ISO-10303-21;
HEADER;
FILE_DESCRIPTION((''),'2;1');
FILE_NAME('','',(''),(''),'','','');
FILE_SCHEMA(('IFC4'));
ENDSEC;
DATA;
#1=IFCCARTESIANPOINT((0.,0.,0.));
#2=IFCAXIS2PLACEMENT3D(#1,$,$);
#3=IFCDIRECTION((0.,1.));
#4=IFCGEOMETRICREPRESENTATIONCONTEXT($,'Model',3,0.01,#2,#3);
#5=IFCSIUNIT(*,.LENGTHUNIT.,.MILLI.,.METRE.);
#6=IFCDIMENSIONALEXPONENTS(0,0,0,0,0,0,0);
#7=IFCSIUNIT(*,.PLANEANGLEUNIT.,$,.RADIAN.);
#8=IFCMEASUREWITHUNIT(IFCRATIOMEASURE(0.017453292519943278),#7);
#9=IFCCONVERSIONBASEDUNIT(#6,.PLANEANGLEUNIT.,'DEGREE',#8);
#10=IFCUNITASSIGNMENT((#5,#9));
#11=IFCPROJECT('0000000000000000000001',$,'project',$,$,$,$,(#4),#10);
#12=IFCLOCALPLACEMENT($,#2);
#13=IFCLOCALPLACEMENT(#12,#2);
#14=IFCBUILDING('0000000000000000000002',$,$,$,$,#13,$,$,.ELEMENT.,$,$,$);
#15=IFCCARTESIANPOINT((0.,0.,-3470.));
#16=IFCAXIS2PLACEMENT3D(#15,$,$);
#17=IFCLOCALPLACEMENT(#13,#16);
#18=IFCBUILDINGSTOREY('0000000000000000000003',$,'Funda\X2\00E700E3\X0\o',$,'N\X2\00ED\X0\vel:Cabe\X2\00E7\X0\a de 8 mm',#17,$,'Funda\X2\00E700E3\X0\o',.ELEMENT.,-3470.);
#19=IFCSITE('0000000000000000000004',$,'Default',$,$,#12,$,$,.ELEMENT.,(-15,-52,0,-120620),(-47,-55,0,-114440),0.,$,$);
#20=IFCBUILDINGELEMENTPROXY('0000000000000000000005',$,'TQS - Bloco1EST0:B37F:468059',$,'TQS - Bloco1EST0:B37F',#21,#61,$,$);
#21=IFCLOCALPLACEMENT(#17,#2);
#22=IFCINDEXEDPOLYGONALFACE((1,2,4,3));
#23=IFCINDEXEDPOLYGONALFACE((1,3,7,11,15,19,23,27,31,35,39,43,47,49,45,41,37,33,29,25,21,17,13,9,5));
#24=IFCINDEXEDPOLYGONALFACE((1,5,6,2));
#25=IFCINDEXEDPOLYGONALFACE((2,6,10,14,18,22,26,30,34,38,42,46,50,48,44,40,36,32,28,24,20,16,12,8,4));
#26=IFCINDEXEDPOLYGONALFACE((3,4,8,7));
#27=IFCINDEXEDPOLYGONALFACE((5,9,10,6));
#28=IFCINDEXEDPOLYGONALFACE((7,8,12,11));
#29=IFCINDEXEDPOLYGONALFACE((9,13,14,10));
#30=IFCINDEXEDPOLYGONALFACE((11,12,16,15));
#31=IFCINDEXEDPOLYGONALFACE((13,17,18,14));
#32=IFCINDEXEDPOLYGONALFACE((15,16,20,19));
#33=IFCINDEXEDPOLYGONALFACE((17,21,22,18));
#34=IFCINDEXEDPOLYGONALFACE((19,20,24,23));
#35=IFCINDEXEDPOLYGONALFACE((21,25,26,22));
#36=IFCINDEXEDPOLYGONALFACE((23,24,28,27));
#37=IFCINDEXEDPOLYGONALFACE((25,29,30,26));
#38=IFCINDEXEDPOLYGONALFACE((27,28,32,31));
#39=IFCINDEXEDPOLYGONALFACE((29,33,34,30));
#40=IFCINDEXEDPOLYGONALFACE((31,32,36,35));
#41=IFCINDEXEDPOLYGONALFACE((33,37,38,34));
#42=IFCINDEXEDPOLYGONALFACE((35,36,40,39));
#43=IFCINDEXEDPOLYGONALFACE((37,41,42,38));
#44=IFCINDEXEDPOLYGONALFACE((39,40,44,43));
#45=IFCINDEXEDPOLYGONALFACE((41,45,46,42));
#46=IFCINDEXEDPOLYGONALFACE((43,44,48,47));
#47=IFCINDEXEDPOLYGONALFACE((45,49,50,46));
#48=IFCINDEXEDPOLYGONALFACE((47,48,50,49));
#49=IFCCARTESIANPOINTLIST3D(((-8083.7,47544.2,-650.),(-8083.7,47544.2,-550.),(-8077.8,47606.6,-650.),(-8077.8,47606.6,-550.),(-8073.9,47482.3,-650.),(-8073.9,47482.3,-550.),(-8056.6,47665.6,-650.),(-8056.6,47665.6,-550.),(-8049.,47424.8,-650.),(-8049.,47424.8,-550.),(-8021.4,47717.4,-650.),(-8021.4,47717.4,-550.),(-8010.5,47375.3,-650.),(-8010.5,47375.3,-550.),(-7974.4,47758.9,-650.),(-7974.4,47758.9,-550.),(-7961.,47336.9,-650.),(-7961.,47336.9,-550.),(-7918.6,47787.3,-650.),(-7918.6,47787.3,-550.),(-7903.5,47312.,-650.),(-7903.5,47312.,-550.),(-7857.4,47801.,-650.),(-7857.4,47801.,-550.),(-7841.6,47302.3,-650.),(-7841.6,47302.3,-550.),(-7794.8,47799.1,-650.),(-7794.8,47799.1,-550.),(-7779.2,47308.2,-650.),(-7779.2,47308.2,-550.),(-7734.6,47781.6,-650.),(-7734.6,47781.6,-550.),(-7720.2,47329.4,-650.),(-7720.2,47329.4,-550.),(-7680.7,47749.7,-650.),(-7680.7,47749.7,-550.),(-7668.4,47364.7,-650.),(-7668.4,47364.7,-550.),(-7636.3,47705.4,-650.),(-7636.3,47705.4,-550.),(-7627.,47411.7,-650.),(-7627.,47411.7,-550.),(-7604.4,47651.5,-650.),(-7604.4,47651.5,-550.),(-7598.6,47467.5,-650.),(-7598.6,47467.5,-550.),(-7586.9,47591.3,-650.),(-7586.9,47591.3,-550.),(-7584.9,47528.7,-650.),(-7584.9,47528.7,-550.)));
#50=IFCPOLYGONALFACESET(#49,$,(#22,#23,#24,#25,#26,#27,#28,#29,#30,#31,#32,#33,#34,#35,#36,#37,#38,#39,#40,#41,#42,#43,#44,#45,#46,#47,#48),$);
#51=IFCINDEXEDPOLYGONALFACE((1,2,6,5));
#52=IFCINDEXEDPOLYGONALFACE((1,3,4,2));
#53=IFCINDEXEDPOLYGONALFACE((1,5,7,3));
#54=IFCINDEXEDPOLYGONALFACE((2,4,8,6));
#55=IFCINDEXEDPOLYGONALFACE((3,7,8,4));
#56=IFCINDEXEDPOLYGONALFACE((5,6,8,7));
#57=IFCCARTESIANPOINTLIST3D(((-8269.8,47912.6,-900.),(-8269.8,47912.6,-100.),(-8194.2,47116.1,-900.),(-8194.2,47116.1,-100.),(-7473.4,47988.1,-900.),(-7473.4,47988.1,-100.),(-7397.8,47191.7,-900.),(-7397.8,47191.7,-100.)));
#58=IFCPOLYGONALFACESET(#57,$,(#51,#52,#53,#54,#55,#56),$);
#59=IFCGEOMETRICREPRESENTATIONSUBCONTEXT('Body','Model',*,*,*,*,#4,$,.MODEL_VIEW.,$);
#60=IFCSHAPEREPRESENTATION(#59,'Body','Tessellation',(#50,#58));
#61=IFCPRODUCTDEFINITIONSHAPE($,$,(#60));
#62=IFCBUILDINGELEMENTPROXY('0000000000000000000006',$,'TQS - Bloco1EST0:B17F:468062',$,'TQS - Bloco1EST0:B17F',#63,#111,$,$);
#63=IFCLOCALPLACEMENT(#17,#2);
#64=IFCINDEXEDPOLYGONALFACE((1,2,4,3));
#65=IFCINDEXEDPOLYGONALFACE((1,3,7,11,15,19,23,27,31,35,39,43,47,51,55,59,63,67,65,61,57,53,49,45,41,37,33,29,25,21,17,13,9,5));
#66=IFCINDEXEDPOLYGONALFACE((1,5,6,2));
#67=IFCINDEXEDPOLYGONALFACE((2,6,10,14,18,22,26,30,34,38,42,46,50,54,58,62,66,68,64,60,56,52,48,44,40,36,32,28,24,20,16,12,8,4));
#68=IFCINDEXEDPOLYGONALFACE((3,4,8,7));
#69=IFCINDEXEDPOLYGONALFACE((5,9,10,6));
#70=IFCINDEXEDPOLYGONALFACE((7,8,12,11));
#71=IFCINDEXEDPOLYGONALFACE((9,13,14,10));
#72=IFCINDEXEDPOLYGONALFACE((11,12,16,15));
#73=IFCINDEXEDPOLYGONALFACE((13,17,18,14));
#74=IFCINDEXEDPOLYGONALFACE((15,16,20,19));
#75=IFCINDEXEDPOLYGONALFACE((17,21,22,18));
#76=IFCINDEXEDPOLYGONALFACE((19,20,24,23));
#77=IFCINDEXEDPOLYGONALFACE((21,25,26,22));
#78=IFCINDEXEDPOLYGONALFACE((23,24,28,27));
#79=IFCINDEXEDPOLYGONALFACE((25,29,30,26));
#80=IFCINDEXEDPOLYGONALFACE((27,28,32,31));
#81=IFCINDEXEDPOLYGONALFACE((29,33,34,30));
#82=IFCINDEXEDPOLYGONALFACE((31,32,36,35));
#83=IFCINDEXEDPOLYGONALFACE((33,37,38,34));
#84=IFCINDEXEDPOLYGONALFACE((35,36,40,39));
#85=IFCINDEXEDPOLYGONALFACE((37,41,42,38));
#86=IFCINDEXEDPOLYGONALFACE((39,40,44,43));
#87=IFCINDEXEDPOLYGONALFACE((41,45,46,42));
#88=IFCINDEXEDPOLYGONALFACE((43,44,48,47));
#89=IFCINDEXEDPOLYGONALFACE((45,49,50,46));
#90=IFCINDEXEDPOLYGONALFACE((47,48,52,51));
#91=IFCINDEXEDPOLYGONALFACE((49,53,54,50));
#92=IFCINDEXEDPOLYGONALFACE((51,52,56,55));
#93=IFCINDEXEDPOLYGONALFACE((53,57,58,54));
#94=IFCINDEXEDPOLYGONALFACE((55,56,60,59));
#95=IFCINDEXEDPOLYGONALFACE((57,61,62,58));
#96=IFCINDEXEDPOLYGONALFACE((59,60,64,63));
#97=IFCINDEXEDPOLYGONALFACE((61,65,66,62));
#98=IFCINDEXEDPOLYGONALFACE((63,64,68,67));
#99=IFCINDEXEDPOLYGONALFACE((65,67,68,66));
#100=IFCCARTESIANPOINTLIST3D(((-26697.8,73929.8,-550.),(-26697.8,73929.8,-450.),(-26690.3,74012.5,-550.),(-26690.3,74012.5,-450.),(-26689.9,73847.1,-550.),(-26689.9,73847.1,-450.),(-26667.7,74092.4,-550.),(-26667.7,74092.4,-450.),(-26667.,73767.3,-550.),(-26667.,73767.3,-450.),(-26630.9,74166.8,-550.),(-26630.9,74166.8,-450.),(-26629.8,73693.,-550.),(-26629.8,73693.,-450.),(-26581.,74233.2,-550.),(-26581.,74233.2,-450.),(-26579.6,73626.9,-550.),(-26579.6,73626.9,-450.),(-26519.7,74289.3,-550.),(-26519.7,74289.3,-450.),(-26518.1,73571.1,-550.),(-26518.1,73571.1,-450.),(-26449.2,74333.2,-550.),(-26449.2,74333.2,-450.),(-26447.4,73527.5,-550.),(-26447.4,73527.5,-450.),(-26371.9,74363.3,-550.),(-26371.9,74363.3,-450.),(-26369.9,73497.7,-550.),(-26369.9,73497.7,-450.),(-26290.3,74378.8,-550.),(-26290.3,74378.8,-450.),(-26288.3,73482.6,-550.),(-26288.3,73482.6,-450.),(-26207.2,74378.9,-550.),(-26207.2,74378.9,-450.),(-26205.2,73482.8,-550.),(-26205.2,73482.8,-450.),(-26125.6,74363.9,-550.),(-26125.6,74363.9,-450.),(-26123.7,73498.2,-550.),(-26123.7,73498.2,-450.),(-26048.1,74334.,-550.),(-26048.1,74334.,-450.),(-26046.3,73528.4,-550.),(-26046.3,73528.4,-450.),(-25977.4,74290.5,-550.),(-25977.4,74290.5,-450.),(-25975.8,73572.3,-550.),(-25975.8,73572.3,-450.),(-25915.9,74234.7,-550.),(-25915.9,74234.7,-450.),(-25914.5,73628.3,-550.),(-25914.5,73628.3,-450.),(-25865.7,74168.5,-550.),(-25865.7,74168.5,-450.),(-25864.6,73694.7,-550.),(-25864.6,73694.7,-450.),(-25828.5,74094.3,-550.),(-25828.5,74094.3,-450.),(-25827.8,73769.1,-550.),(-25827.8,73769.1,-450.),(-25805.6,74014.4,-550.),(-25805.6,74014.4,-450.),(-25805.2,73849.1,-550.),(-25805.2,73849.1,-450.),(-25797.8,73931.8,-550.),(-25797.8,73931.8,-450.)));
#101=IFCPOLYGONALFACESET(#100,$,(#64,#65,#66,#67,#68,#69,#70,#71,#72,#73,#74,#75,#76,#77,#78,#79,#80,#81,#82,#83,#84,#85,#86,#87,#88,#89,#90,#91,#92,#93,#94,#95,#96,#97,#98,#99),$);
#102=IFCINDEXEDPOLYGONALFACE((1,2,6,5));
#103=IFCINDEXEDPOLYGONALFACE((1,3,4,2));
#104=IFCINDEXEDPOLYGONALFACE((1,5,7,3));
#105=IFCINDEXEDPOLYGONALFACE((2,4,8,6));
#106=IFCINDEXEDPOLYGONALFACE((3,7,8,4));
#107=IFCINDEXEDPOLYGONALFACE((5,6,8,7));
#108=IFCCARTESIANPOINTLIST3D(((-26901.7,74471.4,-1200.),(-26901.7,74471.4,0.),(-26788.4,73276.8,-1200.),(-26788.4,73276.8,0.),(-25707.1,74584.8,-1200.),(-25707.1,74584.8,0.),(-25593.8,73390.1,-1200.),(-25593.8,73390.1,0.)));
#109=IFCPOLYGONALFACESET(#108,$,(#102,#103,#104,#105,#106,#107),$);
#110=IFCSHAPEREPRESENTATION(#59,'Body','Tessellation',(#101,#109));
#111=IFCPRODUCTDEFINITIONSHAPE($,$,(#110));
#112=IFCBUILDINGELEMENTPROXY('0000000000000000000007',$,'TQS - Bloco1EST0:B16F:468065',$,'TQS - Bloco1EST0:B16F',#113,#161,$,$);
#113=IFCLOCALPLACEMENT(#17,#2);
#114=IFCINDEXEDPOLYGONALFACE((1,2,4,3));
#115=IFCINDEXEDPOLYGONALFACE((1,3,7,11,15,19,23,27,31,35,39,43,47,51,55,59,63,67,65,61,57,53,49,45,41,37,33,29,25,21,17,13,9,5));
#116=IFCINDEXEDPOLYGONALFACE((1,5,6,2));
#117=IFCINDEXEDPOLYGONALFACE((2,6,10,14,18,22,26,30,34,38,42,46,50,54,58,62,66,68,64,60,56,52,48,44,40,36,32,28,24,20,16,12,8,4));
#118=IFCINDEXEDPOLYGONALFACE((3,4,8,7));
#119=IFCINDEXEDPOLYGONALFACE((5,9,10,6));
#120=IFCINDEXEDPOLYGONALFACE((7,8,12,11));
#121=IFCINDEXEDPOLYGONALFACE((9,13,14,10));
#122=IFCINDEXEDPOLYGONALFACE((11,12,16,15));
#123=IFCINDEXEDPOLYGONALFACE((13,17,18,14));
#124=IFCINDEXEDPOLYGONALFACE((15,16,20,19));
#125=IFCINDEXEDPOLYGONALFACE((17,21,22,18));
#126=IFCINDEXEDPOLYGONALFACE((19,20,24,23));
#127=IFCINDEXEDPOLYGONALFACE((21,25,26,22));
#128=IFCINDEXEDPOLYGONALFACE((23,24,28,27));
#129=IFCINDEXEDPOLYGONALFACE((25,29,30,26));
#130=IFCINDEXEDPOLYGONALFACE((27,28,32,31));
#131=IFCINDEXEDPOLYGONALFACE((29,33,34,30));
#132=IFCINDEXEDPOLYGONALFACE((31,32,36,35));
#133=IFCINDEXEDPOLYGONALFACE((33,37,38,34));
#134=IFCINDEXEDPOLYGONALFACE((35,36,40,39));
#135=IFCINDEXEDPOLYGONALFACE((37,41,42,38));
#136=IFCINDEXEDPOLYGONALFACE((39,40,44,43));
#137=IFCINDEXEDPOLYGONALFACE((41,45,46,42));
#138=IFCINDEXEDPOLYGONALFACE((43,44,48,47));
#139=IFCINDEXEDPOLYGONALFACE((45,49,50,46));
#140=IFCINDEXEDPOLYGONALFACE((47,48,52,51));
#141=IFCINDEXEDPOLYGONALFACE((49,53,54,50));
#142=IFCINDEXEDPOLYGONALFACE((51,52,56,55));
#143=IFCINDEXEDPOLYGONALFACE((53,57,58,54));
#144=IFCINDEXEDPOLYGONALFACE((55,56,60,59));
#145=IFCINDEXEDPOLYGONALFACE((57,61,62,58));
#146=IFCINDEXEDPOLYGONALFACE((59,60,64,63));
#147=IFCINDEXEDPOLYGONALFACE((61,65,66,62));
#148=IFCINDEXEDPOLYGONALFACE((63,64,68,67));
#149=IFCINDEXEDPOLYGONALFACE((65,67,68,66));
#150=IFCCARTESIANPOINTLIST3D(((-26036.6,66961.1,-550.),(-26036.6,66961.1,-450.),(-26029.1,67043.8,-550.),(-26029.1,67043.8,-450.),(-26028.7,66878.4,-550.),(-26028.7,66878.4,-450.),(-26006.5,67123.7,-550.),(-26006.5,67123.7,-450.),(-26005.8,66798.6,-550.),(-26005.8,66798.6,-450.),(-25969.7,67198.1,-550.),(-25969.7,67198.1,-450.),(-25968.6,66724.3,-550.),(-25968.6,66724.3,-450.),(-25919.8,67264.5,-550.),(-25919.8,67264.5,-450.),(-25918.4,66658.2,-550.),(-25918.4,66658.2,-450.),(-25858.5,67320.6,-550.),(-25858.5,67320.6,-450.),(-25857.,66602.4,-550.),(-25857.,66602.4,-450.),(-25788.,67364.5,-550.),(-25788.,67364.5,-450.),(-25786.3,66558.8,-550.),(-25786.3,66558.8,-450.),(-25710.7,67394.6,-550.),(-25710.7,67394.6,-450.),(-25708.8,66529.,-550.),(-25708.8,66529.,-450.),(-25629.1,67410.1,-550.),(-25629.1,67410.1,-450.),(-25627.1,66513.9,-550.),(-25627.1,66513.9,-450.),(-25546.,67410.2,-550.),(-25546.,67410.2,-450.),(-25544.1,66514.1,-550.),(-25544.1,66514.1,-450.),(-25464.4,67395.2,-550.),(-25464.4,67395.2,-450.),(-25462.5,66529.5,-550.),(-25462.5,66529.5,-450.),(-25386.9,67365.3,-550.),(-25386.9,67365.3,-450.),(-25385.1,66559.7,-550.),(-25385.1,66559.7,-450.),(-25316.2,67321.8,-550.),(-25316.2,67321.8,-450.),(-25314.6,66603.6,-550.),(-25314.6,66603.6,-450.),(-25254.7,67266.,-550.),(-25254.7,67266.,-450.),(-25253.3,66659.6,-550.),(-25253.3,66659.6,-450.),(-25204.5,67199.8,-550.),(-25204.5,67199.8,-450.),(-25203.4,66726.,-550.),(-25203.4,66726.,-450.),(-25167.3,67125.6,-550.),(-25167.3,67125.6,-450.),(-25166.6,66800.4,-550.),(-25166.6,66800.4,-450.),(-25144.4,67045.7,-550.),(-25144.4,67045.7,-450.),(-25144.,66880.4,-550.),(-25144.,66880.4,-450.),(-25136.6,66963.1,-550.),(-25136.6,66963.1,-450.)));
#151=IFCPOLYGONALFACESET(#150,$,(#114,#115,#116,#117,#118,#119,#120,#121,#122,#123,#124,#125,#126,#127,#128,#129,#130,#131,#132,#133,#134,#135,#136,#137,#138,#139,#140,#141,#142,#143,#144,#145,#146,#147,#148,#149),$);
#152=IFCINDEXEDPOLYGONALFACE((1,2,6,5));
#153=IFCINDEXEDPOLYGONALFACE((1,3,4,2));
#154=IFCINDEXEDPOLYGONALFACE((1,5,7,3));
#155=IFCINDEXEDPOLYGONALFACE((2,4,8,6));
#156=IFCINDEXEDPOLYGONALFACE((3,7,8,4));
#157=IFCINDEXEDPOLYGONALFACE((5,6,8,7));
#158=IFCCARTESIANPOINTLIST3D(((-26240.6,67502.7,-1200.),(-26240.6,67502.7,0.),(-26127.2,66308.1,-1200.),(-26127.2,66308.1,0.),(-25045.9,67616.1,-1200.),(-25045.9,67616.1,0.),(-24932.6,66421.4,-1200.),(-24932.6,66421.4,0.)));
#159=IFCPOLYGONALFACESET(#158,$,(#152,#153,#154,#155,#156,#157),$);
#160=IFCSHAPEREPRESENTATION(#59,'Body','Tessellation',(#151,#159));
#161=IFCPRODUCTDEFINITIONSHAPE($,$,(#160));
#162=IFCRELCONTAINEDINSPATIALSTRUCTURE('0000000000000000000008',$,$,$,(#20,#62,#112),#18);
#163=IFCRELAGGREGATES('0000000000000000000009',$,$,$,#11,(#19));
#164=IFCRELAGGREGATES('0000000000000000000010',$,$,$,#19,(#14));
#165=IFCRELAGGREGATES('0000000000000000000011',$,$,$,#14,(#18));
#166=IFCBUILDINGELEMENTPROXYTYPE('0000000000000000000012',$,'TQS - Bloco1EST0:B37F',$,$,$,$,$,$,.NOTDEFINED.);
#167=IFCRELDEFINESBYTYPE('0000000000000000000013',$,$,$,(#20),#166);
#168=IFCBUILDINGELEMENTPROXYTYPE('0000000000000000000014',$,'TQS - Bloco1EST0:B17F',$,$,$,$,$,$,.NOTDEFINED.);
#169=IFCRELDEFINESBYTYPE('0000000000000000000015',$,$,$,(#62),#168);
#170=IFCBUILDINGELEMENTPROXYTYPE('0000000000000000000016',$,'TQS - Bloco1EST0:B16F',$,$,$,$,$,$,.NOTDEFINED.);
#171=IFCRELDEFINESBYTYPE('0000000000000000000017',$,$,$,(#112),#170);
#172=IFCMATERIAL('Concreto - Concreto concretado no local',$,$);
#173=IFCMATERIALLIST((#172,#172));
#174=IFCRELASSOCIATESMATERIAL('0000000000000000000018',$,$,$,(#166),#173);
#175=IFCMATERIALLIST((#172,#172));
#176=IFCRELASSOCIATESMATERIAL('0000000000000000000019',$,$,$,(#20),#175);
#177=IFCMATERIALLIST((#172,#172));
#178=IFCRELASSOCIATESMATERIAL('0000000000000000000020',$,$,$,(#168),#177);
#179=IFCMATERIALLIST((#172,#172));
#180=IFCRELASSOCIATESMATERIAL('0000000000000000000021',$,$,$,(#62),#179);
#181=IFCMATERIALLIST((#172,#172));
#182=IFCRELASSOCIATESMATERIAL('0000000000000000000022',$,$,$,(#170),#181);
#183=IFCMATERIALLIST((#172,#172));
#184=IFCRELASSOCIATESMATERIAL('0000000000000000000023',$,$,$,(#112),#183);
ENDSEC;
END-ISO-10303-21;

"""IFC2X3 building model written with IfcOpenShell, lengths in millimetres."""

from ifc_helpers import new_model, entity, si_unit, converted_unit, direction, frame, frame_2d, origin, origin_2d_with_axis, place, context, subcontext, project, spatial, rectangle, circle, extrude, source, transform, mapped, material, material_list, type_object, type_shapes, element, save


model = new_model("IFC2X3")

# Units and contexts
model_context = context("Model", 3, precision=0.01, world=origin(), true_north=direction((0.0, 1.0)))
body_context = subcontext(model_context, "Body", "Model", "MODEL_VIEW")
ifc_project = project(units=[si_unit("LENGTHUNIT", "METRE", prefix="MILLI"), converted_unit("PLANEANGLEUNIT", "DEGREE", entity("IfcRatioMeasure", 0.017453292519943278), si_unit("PLANEANGLEUNIT", "RADIAN"), dimensions=[0, 0, 0, 0, 0, 0, 0])], contexts=[model_context])

# Site, building, storey
site_placement = place(None, origin())
site = spatial("IfcSite", under=ifc_project, at=site_placement, Name="Default", CompositionType="ELEMENT", RefLatitude=(-15, -52, 0, -120620), RefLongitude=(-47, -55, 0, -114440), RefElevation=0.0)
building_placement = place(site_placement, origin())
building = spatial("IfcBuilding", under=site, at=building_placement, CompositionType="ELEMENT")
storey_placement = place(building_placement, frame((0.0, 0.0, -3470.0)))
storey = spatial("IfcBuildingStorey", under=building, at=storey_placement, Name="Fundação", ObjectType="Nível:Cabeça de 8 mm", LongName="Fundação", CompositionType="ELEMENT", Elevation=-3470.0)

# Building element proxies
ifc_material_1 = material(Name="Concreto - Concreto concretado no local")
ifc_material_list_1 = material_list([ifc_material_1, ifc_material_1])
ifc_material_list_2 = material_list([ifc_material_1, ifc_material_1])
building_element_proxy_type_1 = type_object("IfcBuildingElementProxyType", Name="TQS - Bloco1EST0:B37F", PredefinedType="NOTDEFINED", material=ifc_material_list_2)
shared_shape_1 = source(origin(), body_context, "Body", "SweptSolid", [
    extrude(circle(Radius=250.0, at=frame_2d((0.0, 0.0), x_axis=(1.0, 0.0))), frame((0.0, 0.0, -550.0)), (0.0, 0.0, 1.0), 100.0),
    extrude(rectangle(XDim=800.0, YDim=800.0, at=origin_2d_with_axis()), frame((0.0, 0.0, -800.0), z_axis=(0.0, 0.0, 1.0), x_axis=(-1.0, 0.0, 0.0)), (0.0, 0.0, 1.0), 800.0),
])
type_shapes(building_element_proxy_type_1, [shared_shape_1])
proxy_1_placement = place(storey_placement, frame((-7833.8, 47552.1, -100.0), z_axis=(0.0, 0.0, 1.0), x_axis=(-0.094456, 0.995529, 0.0)))
element("IfcBuildingElementProxy", 1, at=proxy_1_placement, inside=storey, type_object=building_element_proxy_type_1, material=ifc_material_list_1, Name="TQS - Bloco1EST0:B37F:468059", ObjectType="TQS - Bloco1EST0:B37F", context=body_context, shape_type="MappedRepresentation", body=[
    mapped(shared_shape_1, transform((0.0, 0.0, 0.0), scale=1.0)),
])
ifc_material_list_3 = material_list([ifc_material_1, ifc_material_1])
ifc_material_list_4 = material_list([ifc_material_1, ifc_material_1])
building_element_proxy_type_2 = type_object("IfcBuildingElementProxyType", Name="TQS - Bloco1EST0:B17F", PredefinedType="NOTDEFINED", material=ifc_material_list_4)
shared_shape_2 = source(origin(), body_context, "Body", "SweptSolid", [
    extrude(circle(Radius=450.0, at=frame_2d((0.0, 0.0), x_axis=(1.0, 0.0))), frame((0.0, 0.0, -550.0)), (0.0, 0.0, 1.0), 100.0),
    extrude(rectangle(XDim=1200.0, YDim=1200.0, at=origin_2d_with_axis()), frame((0.0, 0.0, -1200.0), z_axis=(0.0, 0.0, 1.0), x_axis=(-1.0, 0.0, 0.0)), (0.0, 0.0, 1.0), 1200.0),
])
type_shapes(building_element_proxy_type_2, [shared_shape_2])
proxy_2_placement = place(storey_placement, frame((-26247.8, 73930.8, 0.0), z_axis=(0.0, 0.0, 1.0), x_axis=(-0.094456, 0.995529, 0.0)))
element("IfcBuildingElementProxy", 2, at=proxy_2_placement, inside=storey, type_object=building_element_proxy_type_2, material=ifc_material_list_3, Name="TQS - Bloco1EST0:B17F:468062", ObjectType="TQS - Bloco1EST0:B17F", context=body_context, shape_type="MappedRepresentation", body=[
    mapped(shared_shape_2, transform((0.0, 0.0, 0.0), scale=1.0)),
])
ifc_material_list_5 = material_list([ifc_material_1, ifc_material_1])
ifc_material_list_6 = material_list([ifc_material_1, ifc_material_1])
building_element_proxy_type_3 = type_object("IfcBuildingElementProxyType", Name="TQS - Bloco1EST0:B16F", PredefinedType="NOTDEFINED", material=ifc_material_list_6)
shared_shape_3 = source(origin(), body_context, "Body", "SweptSolid", [
    extrude(circle(Radius=450.0, at=frame_2d((0.0, 0.0), x_axis=(1.0, 0.0))), frame((0.0, 0.0, -550.0)), (0.0, 0.0, 1.0), 100.0),
    extrude(rectangle(XDim=1200.0, YDim=1200.0, at=origin_2d_with_axis()), frame((0.0, 0.0, -1200.0), z_axis=(0.0, 0.0, 1.0), x_axis=(-1.0, 0.0, 0.0)), (0.0, 0.0, 1.0), 1200.0),
])
type_shapes(building_element_proxy_type_3, [shared_shape_3])
proxy_3_placement = place(storey_placement, frame((-25586.6, 66962.1, 0.0), z_axis=(0.0, 0.0, 1.0), x_axis=(-0.094456, 0.995529, 0.0)))
element("IfcBuildingElementProxy", 3, at=proxy_3_placement, inside=storey, type_object=building_element_proxy_type_3, material=ifc_material_list_5, Name="TQS - Bloco1EST0:B16F:468065", ObjectType="TQS - Bloco1EST0:B16F", context=body_context, shape_type="MappedRepresentation", body=[
    mapped(shared_shape_3, transform((0.0, 0.0, 0.0), scale=1.0)),
])

save(model, "model.ifc")
